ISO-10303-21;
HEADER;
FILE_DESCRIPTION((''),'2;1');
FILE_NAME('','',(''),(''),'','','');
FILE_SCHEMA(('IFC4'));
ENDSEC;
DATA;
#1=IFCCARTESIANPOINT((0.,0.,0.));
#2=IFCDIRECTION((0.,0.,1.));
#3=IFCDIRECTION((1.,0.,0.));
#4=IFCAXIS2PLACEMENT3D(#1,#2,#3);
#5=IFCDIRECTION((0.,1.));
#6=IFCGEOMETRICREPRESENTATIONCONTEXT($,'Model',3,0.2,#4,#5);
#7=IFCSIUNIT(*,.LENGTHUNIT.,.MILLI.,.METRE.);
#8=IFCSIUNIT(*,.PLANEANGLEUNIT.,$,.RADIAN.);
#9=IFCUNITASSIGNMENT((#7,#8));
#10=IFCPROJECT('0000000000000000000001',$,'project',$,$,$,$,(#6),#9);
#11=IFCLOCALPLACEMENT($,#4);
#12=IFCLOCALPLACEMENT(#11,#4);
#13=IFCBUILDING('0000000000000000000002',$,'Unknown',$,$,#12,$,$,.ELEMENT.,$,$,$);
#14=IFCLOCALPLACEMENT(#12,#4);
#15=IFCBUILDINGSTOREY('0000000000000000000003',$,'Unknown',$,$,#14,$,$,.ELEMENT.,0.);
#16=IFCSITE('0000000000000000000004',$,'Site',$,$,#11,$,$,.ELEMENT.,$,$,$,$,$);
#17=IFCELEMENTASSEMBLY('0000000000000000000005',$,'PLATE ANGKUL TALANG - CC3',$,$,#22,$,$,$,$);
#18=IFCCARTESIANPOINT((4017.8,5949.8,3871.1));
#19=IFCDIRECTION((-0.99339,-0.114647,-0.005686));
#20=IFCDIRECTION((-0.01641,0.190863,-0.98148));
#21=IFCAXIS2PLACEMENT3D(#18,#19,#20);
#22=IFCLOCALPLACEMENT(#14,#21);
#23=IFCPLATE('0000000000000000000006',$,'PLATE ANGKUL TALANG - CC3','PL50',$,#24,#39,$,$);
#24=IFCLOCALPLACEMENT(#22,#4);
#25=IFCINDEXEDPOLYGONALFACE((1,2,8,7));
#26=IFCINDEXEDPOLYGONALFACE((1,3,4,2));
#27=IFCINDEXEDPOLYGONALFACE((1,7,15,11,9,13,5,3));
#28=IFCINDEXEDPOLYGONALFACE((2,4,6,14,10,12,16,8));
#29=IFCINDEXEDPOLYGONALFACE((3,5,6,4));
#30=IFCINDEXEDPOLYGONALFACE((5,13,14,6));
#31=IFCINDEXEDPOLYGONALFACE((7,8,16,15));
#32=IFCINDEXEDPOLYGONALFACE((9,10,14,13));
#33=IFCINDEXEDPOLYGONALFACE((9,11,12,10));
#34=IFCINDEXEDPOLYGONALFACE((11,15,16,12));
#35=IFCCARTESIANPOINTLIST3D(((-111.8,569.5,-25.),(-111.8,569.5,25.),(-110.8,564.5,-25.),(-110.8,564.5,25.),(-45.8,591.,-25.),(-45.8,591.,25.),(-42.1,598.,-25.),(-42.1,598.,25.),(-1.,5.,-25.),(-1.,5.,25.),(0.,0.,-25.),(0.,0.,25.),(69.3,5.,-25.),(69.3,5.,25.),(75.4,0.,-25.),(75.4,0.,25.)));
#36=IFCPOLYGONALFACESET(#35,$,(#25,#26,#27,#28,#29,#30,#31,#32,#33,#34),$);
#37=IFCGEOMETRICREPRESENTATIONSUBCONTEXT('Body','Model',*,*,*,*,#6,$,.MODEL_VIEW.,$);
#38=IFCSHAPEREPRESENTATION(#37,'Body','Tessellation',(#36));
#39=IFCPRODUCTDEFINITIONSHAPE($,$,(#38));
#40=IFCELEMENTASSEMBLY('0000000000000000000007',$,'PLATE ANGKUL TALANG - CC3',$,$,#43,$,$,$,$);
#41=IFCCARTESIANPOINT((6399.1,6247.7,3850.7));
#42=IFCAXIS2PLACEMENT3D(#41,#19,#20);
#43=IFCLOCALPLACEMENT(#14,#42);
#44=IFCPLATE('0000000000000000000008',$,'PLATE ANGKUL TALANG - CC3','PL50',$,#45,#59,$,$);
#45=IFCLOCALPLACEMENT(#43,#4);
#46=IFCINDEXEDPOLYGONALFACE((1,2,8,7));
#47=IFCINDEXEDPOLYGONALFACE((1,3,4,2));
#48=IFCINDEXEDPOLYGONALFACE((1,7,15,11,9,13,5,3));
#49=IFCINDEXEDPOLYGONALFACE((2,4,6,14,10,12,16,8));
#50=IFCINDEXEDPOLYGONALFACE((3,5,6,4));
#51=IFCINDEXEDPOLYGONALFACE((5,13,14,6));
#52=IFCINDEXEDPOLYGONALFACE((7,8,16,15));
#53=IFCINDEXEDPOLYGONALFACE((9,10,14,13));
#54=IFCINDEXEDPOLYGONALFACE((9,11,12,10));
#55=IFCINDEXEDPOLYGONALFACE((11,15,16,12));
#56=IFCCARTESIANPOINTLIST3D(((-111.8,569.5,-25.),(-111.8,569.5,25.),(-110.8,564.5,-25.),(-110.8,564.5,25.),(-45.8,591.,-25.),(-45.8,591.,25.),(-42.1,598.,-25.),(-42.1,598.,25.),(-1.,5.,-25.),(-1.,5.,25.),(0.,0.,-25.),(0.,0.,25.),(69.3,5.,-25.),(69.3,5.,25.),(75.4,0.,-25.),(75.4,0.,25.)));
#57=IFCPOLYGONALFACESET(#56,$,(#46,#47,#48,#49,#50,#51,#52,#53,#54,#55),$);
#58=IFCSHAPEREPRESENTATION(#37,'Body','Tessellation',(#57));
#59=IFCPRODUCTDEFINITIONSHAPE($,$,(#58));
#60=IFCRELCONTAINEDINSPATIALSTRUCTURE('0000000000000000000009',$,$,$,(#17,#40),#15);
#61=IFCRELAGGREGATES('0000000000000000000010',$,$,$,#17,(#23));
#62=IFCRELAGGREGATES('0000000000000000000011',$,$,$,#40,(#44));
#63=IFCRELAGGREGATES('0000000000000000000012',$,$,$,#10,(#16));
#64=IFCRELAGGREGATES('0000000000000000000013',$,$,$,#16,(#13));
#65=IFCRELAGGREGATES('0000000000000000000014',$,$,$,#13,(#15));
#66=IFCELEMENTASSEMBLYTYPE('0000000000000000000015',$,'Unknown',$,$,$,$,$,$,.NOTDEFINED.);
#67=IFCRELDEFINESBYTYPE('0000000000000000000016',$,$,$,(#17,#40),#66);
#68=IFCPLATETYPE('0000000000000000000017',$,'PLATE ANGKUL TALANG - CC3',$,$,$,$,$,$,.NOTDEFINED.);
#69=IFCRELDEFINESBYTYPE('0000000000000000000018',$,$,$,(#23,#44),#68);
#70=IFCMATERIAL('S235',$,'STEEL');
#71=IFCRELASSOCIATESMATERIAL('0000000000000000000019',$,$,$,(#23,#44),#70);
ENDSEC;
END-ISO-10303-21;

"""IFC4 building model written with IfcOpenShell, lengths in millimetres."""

from ifc_helpers import new_model, si_unit, direction, frame, origin_with_axes, place, context, subcontext, project, spatial, line, indexed_curve, outline, extrude, material, material_profile, profile_set, profile_usage, type_object, element, aggregate, save


model = new_model("IFC4")

# Units and contexts
model_context = context("Model", 3, precision=0.2, world=origin_with_axes(), true_north=direction((0.0, 1.0)))
body_context = subcontext(model_context, "Body", "Model", "MODEL_VIEW")
ifc_project = project(units=[si_unit("LENGTHUNIT", "METRE", prefix="MILLI"), si_unit("PLANEANGLEUNIT", "RADIAN")], contexts=[model_context])

# Site, building, storey
site_placement = place(None, origin_with_axes())
site = spatial("IfcSite", under=ifc_project, at=site_placement, Name="Site", CompositionType="ELEMENT")
building_placement = place(site_placement, origin_with_axes())
building = spatial("IfcBuilding", under=site, at=building_placement, Name="Unknown", CompositionType="ELEMENT")
storey_placement = place(building_placement, origin_with_axes())
storey = spatial("IfcBuildingStorey", under=building, at=storey_placement, Name="Unknown", CompositionType="ELEMENT", Elevation=0.0)

# Shared definitions
element_assembly_type = type_object("IfcElementAssemblyType", Name="Unknown", PredefinedType="NOTDEFINED")
ifc_material_1 = material(Name="S235", Category="STEEL")

# Element assemblies, plates
ifc_material_profile_1 = material_profile(ifc_material_1, outline(indexed_curve([(0.0, 0.0), (75.4, 0.0), (-42.1, 598.0), (-111.8, 569.5), (-110.8, 564.5), (-45.8, 591.0), (69.3, 5.0), (-1.0, 5.0)], segments=[line(1, 2, 3, 4, 5, 6, 7, 8, 1)])), Name="PL50")
ifc_profile_set_1 = profile_set([ifc_material_profile_1])
ifc_profile_usage_1 = profile_usage(ifc_profile_set_1, cardinal=5)
plate_type_1 = type_object("IfcPlateType", Name="PLATE ANGKUL TALANG - CC3", PredefinedType="NOTDEFINED")
assembly_1_placement = place(storey_placement, frame((4017.8, 5949.8, 3871.1), z_axis=(-0.99339, -0.114647, -0.005686), x_axis=(-0.01641, 0.190863, -0.98148)))
assembly_1 = element("IfcElementAssembly", 1, at=assembly_1_placement, inside=storey, type_object=element_assembly_type, Name="PLATE ANGKUL TALANG - CC3")
plate_1_placement = place(assembly_1_placement, origin_with_axes())
plate_1 = element("IfcPlate", 2, at=plate_1_placement, type_object=plate_type_1, material=ifc_profile_usage_1, Name="PLATE ANGKUL TALANG - CC3", Description="PL50", context=body_context, shape_type="SolidModel", body=[
    extrude(outline(indexed_curve([(0.0, 0.0), (75.4, 0.0), (-42.1, 598.0), (-111.8, 569.5), (-110.8, 564.5), (-45.8, 591.0), (69.3, 5.0), (-1.0, 5.0)], segments=[line(1, 2, 3, 4, 5, 6, 7, 8, 1)])), frame((0.0, 0.0, 25.0), z_axis=(0.0, 0.0, 1.0), x_axis=(1.0, 0.0, 0.0)), (0.0, 0.0, -1.0), 50.0),
])
aggregate(assembly_1, [plate_1])
assembly_2_placement = place(storey_placement, frame((6399.1, 6247.7, 3850.7), z_axis=(-0.99339, -0.114647, -0.005686), x_axis=(-0.01641, 0.190863, -0.98148)))
assembly_2 = element("IfcElementAssembly", 3, at=assembly_2_placement, inside=storey, type_object=element_assembly_type, Name="PLATE ANGKUL TALANG - CC3")
plate_2_placement = place(assembly_2_placement, origin_with_axes())
plate_2 = element("IfcPlate", 4, at=plate_2_placement, type_object=plate_type_1, material=ifc_profile_usage_1, Name="PLATE ANGKUL TALANG - CC3", Description="PL50", context=body_context, shape_type="SolidModel", body=[
    extrude(outline(indexed_curve([(0.0, 0.0), (75.4, 0.0), (-42.1, 598.0), (-111.8, 569.5), (-110.8, 564.5), (-45.8, 591.0), (69.3, 5.0), (-1.0, 5.0)], segments=[line(1, 2, 3, 4, 5, 6, 7, 8, 1)])), frame((0.0, 0.0, 25.0), z_axis=(0.0, 0.0, 1.0), x_axis=(1.0, 0.0, 0.0)), (0.0, 0.0, -1.0), 50.0),
])
aggregate(assembly_2, [plate_2])

save(model, "model.ifc")
